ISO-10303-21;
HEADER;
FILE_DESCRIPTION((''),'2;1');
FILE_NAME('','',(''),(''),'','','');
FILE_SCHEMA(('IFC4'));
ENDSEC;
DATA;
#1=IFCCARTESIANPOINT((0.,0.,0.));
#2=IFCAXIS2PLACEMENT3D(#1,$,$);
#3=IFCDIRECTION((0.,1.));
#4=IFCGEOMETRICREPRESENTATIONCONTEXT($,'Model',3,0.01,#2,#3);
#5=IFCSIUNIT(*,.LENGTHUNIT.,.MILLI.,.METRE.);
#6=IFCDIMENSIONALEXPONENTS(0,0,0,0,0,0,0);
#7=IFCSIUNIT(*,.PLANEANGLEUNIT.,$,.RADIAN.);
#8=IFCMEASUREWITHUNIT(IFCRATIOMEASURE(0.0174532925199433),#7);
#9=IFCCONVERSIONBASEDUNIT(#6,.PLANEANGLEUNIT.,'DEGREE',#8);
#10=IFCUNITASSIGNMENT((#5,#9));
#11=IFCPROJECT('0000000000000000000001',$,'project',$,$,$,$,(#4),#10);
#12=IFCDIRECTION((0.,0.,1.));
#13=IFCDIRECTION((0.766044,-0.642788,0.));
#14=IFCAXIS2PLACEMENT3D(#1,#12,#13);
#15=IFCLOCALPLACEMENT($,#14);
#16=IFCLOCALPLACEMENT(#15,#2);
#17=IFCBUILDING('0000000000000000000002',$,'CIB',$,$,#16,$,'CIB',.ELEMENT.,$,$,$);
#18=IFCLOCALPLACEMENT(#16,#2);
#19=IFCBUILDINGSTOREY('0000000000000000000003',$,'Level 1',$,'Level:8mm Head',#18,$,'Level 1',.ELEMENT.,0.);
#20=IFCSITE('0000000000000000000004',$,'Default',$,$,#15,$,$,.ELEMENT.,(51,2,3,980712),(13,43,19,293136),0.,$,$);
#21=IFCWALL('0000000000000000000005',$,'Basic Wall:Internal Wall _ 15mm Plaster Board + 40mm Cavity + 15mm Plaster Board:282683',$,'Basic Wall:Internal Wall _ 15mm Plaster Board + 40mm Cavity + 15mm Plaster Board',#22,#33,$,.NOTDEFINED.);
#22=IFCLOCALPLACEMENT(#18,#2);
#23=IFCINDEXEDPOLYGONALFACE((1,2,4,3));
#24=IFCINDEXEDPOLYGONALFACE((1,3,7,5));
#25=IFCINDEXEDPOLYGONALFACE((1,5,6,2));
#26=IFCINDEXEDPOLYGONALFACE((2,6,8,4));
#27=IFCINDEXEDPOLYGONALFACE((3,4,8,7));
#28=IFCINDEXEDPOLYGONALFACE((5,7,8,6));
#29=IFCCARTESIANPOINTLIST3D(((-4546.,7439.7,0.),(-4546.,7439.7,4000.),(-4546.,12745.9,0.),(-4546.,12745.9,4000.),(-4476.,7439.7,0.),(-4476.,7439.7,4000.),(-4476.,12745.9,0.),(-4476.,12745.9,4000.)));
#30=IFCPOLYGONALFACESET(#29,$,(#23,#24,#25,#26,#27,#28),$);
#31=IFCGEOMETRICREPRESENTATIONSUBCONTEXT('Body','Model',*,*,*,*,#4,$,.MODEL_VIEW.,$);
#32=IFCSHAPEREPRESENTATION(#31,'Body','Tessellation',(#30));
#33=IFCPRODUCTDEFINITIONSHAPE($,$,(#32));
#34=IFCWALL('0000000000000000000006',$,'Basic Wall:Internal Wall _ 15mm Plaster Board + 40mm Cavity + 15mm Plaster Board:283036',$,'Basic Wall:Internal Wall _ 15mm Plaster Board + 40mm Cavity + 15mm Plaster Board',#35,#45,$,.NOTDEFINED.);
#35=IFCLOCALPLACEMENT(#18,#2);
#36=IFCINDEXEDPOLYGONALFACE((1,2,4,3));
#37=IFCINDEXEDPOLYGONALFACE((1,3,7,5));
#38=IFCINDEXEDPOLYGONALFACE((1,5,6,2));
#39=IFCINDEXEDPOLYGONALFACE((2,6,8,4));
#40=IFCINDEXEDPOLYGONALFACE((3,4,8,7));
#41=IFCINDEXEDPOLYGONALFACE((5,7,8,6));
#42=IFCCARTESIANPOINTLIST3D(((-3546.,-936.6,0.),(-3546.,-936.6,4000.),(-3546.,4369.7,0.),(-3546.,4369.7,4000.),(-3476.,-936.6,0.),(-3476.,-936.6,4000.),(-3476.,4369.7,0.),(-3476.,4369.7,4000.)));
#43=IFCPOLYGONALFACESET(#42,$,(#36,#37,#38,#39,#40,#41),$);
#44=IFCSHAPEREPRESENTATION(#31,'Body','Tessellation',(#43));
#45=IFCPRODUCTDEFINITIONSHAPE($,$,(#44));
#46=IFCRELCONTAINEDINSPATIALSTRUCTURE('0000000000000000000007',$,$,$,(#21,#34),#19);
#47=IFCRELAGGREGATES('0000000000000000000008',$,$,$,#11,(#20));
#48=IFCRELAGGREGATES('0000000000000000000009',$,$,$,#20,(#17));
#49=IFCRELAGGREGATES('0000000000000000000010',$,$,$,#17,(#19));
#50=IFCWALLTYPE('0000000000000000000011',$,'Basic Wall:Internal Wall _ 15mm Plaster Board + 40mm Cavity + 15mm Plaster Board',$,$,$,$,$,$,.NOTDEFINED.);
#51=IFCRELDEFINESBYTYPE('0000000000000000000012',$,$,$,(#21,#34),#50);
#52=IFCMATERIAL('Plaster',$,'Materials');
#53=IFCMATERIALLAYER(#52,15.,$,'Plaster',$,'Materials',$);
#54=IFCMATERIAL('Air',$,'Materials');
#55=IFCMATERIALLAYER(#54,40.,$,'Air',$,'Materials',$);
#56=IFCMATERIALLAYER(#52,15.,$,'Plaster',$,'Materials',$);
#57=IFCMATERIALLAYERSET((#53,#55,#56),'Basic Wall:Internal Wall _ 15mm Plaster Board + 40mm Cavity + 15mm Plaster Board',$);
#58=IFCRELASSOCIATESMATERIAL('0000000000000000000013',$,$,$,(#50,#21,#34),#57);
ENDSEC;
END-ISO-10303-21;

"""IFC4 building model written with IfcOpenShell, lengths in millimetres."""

from ifc_helpers import new_model, entity, si_unit, converted_unit, direction, frame, origin, place, context, subcontext, project, spatial, indexed_curve, outline, extrude, material, layer, layer_set, type_object, element, save


model = new_model("IFC4")

# Units and contexts
model_context = context("Model", 3, precision=0.01, world=origin(), true_north=direction((0.0, 1.0)))
body_context = subcontext(model_context, "Body", "Model", "MODEL_VIEW")
ifc_project = project(units=[si_unit("LENGTHUNIT", "METRE", prefix="MILLI"), converted_unit("PLANEANGLEUNIT", "DEGREE", entity("IfcRatioMeasure", 0.0174532925199433), si_unit("PLANEANGLEUNIT", "RADIAN"), dimensions=[0, 0, 0, 0, 0, 0, 0])], contexts=[model_context])

# Site, building, storey
site_placement = place(None, frame((0.0, 0.0, 0.0), z_axis=(0.0, 0.0, 1.0), x_axis=(0.766044, -0.642788, 0.0)))
site = spatial("IfcSite", under=ifc_project, at=site_placement, Name="Default", CompositionType="ELEMENT", RefLatitude=(51, 2, 3, 980712), RefLongitude=(13, 43, 19, 293136), RefElevation=0.0)
building_placement = place(site_placement, origin())
building = spatial("IfcBuilding", under=site, at=building_placement, Name="CIB", LongName="CIB", CompositionType="ELEMENT")
storey_placement = place(building_placement, origin())
storey = spatial("IfcBuildingStorey", under=building, at=storey_placement, Name="Level 1", ObjectType="Level:8mm Head", LongName="Level 1", CompositionType="ELEMENT", Elevation=0.0)

# Walls
ifc_material_1 = material(Name="Plaster", Category="Materials")
ifc_layer_1 = layer(ifc_material_1, 15.0, Name="Plaster", Category="Materials")
ifc_material_2 = material(Name="Air", Category="Materials")
ifc_layer_2 = layer(ifc_material_2, 40.0, Name="Air", Category="Materials")
ifc_layer_3 = layer(ifc_material_1, 15.0, Name="Plaster", Category="Materials")
ifc_layer_set_1 = layer_set([ifc_layer_1, ifc_layer_2, ifc_layer_3], Name="Basic Wall:Internal Wall _ 15mm Plaster Board + 40mm Cavity + 15mm Plaster Board")
wall_type = type_object("IfcWallType", Name="Basic Wall:Internal Wall _ 15mm Plaster Board + 40mm Cavity + 15mm Plaster Board", PredefinedType="NOTDEFINED", material=ifc_layer_set_1)
wall_1_placement = place(storey_placement, frame((-4511.0, 7439.7, 0.0), z_axis=(0.0, 0.0, 1.0), x_axis=(0.0, 1.0, 0.0)))
element("IfcWall", 1, at=wall_1_placement, inside=storey, type_object=wall_type, material=ifc_layer_set_1, Name="Basic Wall:Internal Wall _ 15mm Plaster Board + 40mm Cavity + 15mm Plaster Board:282683", ObjectType="Basic Wall:Internal Wall _ 15mm Plaster Board + 40mm Cavity + 15mm Plaster Board", PredefinedType="NOTDEFINED", context=body_context, shape_type="SweptSolid", body=[
    extrude(outline(indexed_curve([(5306.2, 35.0), (0.0, 35.0), (0.0, -35.0), (5306.2, -35.0), (5306.2, 35.0)], self_intersect=False)), origin(), (0.0, 0.0, 1.0), 4000.0),
])
wall_2_placement = place(storey_placement, frame((-3511.0, 4369.7, 0.0), z_axis=(0.0, 0.0, 1.0), x_axis=(0.0, -1.0, 0.0)))
element("IfcWall", 2, at=wall_2_placement, inside=storey, type_object=wall_type, material=ifc_layer_set_1, Name="Basic Wall:Internal Wall _ 15mm Plaster Board + 40mm Cavity + 15mm Plaster Board:283036", ObjectType="Basic Wall:Internal Wall _ 15mm Plaster Board + 40mm Cavity + 15mm Plaster Board", PredefinedType="NOTDEFINED", context=body_context, shape_type="SweptSolid", body=[
    extrude(outline(indexed_curve([(5306.2, 35.0), (0.0, 35.0), (0.0, -35.0), (5306.2, -35.0), (5306.2, 35.0)], self_intersect=False)), origin(), (0.0, 0.0, 1.0), 4000.0),
])

save(model, "model.ifc")
